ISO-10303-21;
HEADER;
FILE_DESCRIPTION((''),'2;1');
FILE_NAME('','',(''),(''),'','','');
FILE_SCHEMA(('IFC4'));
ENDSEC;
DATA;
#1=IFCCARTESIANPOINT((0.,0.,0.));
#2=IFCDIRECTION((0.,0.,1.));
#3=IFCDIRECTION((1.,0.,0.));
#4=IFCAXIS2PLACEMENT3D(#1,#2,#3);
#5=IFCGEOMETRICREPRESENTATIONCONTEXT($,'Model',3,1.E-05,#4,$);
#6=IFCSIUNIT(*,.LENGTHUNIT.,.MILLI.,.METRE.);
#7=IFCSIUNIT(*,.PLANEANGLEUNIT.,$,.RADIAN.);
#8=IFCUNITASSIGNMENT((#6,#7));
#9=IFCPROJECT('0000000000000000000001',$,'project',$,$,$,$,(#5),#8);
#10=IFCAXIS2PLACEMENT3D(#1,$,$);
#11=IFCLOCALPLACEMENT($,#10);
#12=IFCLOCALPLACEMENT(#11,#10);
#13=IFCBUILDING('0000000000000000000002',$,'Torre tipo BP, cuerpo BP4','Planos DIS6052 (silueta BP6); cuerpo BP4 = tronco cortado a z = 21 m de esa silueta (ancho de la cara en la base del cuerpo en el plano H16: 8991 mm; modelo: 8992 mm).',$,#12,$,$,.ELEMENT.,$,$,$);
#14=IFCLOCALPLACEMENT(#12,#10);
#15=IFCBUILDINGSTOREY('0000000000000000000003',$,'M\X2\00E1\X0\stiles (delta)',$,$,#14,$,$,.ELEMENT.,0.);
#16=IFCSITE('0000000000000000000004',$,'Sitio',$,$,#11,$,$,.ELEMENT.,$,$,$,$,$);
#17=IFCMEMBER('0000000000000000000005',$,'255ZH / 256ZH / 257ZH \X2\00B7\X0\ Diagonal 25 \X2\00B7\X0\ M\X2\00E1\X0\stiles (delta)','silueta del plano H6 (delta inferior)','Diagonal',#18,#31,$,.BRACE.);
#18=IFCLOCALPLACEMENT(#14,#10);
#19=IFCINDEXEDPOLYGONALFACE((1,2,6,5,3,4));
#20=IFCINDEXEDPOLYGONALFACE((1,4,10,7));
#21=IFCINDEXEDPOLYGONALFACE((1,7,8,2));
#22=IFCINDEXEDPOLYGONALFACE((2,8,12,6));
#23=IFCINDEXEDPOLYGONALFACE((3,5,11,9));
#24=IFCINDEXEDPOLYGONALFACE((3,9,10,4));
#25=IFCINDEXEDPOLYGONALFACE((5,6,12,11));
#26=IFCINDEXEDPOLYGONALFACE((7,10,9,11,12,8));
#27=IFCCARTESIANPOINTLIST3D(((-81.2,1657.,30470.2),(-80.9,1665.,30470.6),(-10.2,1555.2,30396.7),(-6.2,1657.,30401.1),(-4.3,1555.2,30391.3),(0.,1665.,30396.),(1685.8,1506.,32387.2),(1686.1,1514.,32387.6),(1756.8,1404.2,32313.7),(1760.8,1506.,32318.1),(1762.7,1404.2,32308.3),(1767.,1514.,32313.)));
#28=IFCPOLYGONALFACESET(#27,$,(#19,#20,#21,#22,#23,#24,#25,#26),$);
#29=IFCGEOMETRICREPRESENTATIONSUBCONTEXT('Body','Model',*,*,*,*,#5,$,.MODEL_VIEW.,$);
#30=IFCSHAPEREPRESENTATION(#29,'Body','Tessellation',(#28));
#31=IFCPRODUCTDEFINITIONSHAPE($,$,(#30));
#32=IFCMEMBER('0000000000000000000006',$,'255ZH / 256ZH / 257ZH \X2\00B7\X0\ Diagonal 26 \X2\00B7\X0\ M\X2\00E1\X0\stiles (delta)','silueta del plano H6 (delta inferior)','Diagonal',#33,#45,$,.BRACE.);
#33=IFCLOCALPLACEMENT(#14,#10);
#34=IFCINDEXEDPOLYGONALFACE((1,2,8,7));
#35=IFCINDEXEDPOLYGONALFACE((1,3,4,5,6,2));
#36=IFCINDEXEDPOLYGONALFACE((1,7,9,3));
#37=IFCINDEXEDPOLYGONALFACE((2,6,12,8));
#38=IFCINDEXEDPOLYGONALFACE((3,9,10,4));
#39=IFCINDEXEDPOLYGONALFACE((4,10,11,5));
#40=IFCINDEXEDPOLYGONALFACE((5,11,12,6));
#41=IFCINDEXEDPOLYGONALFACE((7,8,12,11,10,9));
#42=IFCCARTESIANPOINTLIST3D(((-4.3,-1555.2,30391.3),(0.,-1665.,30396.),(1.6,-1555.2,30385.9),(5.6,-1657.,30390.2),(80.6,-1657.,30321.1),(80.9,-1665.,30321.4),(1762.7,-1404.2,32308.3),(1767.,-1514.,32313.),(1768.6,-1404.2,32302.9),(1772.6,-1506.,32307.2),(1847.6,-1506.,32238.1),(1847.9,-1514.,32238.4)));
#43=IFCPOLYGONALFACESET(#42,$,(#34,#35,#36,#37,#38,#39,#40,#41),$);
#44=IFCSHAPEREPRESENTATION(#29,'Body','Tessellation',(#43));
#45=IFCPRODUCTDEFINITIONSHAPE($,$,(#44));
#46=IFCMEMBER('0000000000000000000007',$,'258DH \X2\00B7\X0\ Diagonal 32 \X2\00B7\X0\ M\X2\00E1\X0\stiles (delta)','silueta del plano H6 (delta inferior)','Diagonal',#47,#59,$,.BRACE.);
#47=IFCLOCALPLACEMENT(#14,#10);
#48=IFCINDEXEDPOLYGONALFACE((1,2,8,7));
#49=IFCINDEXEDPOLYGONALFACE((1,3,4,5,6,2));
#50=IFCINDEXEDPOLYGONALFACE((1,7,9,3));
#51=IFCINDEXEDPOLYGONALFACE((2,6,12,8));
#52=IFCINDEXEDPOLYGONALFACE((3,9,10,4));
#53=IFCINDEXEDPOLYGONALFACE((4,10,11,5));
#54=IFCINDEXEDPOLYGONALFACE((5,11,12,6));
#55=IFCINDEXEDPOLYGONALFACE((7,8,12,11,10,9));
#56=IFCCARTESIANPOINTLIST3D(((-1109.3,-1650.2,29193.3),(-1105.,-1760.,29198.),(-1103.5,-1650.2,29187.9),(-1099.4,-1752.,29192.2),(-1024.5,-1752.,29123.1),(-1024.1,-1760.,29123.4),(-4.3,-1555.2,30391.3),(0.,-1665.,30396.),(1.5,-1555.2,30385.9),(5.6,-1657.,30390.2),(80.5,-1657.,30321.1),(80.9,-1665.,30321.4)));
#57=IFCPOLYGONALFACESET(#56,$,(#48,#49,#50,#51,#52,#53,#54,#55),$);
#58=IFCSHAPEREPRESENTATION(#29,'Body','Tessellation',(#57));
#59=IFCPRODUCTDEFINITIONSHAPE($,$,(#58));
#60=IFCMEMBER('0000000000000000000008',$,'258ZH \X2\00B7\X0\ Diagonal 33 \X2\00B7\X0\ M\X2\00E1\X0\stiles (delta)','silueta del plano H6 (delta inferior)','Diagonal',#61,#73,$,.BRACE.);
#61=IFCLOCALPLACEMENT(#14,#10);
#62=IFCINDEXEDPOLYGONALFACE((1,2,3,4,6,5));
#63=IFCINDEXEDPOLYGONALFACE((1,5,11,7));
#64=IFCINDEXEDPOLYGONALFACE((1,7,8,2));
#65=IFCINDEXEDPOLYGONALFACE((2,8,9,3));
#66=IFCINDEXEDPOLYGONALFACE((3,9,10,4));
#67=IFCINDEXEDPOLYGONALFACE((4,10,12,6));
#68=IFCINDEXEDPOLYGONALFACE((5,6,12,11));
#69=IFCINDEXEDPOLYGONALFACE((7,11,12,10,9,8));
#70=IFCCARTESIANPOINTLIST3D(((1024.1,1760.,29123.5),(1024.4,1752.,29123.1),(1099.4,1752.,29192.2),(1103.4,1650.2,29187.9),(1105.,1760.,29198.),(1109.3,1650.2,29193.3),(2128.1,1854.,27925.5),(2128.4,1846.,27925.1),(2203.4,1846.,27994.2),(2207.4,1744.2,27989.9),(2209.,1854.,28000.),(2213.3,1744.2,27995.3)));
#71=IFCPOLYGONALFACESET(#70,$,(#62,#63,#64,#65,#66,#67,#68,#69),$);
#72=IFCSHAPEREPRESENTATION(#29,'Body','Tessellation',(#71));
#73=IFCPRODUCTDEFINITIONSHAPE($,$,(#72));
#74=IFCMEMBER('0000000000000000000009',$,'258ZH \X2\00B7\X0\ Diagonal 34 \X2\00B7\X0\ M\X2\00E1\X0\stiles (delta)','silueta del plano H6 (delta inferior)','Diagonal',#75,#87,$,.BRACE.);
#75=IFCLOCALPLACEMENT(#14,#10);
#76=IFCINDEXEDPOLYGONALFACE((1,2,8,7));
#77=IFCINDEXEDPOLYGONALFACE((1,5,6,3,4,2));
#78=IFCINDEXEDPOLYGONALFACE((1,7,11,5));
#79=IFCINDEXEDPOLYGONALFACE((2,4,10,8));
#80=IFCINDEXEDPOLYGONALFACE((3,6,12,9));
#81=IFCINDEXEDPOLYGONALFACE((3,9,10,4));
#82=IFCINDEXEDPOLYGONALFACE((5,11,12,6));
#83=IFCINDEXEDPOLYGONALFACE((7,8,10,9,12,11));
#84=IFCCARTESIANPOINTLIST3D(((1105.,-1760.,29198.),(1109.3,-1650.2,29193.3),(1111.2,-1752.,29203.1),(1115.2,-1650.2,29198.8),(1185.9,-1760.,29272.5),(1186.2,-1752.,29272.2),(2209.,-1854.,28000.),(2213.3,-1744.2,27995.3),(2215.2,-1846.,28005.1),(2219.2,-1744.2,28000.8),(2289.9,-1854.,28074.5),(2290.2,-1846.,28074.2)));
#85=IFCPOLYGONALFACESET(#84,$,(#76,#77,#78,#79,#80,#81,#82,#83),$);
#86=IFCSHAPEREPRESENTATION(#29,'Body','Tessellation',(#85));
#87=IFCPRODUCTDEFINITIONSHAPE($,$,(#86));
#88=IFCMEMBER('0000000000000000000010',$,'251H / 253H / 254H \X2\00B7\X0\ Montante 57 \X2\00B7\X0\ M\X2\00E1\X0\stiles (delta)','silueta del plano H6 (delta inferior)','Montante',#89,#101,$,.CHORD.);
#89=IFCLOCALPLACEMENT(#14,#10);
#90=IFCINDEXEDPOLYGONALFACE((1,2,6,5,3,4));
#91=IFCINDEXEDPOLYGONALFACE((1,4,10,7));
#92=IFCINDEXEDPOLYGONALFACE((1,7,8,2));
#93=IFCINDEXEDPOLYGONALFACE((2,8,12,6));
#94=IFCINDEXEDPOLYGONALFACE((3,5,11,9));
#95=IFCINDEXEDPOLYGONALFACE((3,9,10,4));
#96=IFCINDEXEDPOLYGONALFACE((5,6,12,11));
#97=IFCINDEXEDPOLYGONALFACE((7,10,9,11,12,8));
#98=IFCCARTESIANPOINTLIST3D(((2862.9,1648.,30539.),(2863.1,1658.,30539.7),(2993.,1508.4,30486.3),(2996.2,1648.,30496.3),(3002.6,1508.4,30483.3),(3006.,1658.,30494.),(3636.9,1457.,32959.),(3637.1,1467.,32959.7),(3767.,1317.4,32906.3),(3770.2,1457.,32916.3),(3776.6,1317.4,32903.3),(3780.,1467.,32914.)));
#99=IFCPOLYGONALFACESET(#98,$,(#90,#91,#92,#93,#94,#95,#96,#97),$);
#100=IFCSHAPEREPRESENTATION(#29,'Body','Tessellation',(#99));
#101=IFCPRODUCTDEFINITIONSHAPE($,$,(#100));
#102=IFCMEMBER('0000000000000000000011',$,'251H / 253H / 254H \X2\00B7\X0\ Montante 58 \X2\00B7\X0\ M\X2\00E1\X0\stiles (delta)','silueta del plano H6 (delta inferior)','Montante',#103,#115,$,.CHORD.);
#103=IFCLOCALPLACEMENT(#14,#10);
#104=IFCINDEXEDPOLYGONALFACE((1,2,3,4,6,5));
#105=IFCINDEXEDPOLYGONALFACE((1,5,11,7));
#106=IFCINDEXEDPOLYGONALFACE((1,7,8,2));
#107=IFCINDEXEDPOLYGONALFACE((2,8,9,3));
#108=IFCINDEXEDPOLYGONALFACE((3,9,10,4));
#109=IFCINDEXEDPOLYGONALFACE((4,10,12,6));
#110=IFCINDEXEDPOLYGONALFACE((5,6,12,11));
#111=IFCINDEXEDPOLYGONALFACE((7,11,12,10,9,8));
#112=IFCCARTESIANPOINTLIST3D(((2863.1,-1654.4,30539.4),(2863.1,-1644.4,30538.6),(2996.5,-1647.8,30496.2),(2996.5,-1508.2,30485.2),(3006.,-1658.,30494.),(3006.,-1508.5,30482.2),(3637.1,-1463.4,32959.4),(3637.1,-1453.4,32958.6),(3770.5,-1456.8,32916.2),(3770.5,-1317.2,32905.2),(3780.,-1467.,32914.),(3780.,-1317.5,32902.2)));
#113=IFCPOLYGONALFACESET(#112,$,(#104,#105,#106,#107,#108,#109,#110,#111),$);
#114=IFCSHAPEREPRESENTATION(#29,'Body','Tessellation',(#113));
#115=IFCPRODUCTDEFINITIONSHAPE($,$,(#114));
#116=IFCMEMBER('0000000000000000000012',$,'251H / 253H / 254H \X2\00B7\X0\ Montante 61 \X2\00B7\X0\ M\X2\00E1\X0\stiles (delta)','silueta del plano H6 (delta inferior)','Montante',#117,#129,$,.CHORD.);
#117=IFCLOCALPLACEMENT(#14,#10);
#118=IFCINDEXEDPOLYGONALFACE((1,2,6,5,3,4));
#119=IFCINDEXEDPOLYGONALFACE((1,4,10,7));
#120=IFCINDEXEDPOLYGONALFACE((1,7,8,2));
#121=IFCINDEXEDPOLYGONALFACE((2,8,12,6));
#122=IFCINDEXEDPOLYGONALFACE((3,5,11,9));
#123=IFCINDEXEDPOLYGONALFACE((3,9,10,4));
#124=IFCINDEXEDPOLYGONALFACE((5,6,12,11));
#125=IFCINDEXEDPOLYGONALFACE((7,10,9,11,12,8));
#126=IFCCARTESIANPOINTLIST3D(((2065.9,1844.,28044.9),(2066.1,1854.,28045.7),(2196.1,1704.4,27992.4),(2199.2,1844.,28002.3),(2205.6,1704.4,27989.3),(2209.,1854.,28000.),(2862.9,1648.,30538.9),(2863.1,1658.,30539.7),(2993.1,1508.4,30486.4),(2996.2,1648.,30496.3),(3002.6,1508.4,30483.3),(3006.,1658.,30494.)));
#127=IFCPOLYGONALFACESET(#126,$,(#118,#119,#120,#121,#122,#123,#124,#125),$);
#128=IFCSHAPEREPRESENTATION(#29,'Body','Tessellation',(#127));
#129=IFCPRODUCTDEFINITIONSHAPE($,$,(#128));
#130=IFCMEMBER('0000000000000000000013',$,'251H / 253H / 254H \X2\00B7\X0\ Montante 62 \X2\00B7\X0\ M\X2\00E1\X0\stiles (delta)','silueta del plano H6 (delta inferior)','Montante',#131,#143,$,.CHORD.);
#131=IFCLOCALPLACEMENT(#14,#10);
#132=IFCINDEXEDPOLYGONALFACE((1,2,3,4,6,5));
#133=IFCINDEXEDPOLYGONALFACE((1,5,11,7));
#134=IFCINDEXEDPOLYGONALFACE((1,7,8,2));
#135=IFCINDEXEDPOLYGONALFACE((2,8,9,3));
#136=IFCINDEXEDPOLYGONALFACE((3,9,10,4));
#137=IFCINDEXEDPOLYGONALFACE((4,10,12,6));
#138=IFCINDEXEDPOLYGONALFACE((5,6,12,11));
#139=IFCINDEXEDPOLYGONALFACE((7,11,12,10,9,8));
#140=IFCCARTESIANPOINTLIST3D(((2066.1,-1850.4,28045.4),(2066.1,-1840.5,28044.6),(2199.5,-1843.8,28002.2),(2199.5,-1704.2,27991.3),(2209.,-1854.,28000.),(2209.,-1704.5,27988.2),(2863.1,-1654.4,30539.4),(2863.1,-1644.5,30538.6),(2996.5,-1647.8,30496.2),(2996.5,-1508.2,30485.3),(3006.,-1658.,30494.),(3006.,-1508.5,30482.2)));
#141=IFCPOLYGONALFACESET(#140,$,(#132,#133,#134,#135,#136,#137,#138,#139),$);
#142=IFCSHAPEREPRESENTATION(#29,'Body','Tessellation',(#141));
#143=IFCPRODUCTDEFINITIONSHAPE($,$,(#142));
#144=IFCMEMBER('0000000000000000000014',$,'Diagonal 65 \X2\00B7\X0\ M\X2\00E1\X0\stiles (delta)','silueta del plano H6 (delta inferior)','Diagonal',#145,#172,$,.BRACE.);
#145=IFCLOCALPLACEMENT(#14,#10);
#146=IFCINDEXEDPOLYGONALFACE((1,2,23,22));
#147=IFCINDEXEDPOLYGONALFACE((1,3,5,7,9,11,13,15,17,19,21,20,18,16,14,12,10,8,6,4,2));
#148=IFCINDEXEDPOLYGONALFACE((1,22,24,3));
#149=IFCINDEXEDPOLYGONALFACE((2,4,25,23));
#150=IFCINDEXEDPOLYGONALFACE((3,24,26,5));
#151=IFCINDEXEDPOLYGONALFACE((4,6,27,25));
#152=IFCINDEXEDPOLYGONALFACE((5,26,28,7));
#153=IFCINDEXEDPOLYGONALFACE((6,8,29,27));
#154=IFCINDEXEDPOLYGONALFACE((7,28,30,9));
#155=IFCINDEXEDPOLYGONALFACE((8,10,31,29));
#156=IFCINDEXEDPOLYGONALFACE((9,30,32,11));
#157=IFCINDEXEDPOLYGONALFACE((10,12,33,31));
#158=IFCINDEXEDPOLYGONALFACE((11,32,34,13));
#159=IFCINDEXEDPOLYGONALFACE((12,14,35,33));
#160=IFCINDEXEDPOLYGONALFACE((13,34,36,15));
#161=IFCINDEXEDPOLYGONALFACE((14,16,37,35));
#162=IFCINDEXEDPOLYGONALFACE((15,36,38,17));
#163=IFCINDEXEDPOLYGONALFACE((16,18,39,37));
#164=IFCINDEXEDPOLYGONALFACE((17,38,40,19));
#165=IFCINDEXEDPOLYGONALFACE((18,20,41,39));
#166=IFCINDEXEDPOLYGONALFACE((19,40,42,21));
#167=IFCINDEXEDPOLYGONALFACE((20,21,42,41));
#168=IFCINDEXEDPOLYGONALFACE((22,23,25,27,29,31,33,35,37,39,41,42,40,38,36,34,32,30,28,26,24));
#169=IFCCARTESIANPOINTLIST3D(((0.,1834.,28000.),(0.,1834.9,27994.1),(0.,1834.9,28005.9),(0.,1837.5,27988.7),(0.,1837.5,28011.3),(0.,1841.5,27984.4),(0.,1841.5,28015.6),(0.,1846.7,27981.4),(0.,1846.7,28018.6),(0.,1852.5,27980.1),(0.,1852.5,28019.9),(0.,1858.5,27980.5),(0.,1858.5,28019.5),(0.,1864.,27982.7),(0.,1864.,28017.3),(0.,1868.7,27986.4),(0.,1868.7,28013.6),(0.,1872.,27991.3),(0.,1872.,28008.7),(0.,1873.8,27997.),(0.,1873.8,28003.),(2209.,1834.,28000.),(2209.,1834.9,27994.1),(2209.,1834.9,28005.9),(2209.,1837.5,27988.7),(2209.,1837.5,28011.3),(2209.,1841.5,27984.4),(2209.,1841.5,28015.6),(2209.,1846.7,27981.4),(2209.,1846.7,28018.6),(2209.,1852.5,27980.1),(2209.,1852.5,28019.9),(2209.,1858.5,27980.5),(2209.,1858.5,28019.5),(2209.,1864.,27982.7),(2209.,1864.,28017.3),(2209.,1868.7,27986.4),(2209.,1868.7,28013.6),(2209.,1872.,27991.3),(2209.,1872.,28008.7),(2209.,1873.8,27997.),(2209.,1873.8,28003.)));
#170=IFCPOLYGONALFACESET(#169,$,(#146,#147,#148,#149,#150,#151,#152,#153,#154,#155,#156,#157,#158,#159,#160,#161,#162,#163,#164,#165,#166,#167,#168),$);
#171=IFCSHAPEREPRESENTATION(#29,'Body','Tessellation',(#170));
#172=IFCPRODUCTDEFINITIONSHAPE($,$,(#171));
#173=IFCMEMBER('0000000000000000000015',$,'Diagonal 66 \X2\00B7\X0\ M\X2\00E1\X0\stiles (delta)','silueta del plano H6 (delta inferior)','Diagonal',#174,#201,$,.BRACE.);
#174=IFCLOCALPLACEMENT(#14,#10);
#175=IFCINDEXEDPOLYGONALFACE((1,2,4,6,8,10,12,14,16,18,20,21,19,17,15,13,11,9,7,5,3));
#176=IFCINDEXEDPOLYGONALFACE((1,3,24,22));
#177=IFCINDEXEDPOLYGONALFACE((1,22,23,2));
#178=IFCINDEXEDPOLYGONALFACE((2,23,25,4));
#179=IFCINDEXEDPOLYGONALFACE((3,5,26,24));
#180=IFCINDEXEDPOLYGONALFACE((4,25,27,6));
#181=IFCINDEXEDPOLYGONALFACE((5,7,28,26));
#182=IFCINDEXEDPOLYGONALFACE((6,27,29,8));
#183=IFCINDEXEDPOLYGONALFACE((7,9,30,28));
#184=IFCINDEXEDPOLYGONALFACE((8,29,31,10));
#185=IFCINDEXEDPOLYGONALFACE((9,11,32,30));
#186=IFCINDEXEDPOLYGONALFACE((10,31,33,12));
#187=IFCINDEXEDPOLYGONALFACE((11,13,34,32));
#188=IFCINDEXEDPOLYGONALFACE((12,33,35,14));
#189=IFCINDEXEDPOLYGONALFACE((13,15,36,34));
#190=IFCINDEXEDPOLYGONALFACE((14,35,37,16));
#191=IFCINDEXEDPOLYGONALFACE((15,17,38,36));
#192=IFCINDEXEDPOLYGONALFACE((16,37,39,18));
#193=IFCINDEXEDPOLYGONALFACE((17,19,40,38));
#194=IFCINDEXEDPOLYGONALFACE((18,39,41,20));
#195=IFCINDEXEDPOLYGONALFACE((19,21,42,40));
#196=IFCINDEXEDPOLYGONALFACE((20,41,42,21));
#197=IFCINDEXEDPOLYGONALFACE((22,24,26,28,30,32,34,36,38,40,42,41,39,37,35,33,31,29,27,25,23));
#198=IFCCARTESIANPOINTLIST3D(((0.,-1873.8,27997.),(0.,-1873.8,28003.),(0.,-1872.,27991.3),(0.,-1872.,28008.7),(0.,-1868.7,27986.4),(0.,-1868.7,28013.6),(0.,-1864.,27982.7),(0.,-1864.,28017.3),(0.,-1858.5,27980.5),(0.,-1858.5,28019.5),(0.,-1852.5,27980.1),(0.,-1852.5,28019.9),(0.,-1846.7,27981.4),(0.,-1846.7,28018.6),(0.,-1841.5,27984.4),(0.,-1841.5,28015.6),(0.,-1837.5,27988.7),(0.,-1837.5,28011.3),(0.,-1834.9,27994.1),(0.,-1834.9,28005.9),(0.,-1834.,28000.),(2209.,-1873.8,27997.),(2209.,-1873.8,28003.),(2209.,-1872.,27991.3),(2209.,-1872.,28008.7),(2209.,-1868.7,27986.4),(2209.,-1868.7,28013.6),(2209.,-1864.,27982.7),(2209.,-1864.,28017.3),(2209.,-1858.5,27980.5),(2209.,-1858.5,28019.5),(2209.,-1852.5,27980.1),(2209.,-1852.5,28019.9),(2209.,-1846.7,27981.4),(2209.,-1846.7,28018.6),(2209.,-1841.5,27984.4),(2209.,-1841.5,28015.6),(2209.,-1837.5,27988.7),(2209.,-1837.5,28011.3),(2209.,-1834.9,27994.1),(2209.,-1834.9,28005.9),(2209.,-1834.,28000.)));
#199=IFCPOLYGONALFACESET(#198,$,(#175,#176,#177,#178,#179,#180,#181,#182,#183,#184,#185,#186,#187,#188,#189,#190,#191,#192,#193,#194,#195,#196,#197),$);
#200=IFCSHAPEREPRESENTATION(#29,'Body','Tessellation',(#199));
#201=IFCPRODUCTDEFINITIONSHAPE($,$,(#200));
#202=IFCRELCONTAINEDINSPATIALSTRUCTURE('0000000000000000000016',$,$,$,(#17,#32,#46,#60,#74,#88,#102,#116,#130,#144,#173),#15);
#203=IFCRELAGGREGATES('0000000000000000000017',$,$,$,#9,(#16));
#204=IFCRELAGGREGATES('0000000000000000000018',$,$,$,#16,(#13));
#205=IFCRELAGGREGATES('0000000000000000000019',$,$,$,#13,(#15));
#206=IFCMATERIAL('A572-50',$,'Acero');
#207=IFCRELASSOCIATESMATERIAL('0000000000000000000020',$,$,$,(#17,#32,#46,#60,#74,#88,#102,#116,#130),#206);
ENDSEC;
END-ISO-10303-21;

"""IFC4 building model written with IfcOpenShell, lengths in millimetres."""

from ifc_helpers import new_model, si_unit, frame, frame_2d, origin, origin_with_axes, place, context, subcontext, project, spatial, circle, l_section, extrude, material, element, save


model = new_model("IFC4")

# Units and contexts
model_context = context("Model", 3, precision=1e-05, world=origin_with_axes())
body_context = subcontext(model_context, "Body", "Model", "MODEL_VIEW")
ifc_project = project(units=[si_unit("LENGTHUNIT", "METRE", prefix="MILLI"), si_unit("PLANEANGLEUNIT", "RADIAN")], contexts=[model_context])

# Site, building, storey
site_placement = place(None, origin())
site = spatial("IfcSite", under=ifc_project, at=site_placement, Name="Sitio", CompositionType="ELEMENT")
building_placement = place(site_placement, origin())
building = spatial("IfcBuilding", under=site, at=building_placement, Name="Torre tipo BP, cuerpo BP4", Description="Planos DIS6052 (silueta BP6); cuerpo BP4 = tronco cortado a z = 21 m de esa silueta (ancho de la cara en la base del cuerpo en el plano H16: 8991 mm; modelo: 8992 mm).", CompositionType="ELEMENT")
storey_placement = place(building_placement, origin())
storey = spatial("IfcBuildingStorey", under=building, at=storey_placement, Name="Mástiles (delta)", CompositionType="ELEMENT", Elevation=0.0)

# Members
ifc_material = material(Name="A572-50", Category="Acero")
for number, where, z_axis, x_axis, name in (
    (1, (1767.0, 1514.0, 32313.0), (-0.67662, 0.057821, -0.734058), (-0.039188, -0.998327, -0.042515), "255ZH / 256ZH / 257ZH · Diagonal 25 · Mástiles (delta)"),
    (2, (1767.0, -1514.0, 32313.0), (-0.67662, -0.057821, -0.734058), (-0.039188, 0.998327, -0.042515), "255ZH / 256ZH / 257ZH · Diagonal 26 · Mástiles (delta)"),
):
    element("IfcMember", number, at=place(storey_placement, frame(where, z_axis=z_axis, x_axis=x_axis)), inside=storey, material=ifc_material, Name=name, Description="silueta del plano H6 (delta inferior)", ObjectType="Diagonal", PredefinedType="BRACE", context=body_context, shape_type="SweptSolid", body=[
        extrude(l_section(Depth=110.0, Width=110.0, Thickness=8.0, at=frame_2d((55.0, 55.0))), None, (0.0, 0.0, 1.0), 2611.5),
    ])
member_1_placement = place(storey_placement, frame((0.0, -1665.0, 30396.0), z_axis=(-0.676851, -0.058191, -0.733817), x_axis=(-0.039453, 0.998305, -0.042774)))
element("IfcMember", 3, at=member_1_placement, inside=storey, material=ifc_material, Name="258DH · Diagonal 32 · Mástiles (delta)", Description="silueta del plano H6 (delta inferior)", ObjectType="Diagonal", PredefinedType="BRACE", context=body_context, shape_type="SweptSolid", body=[
    extrude(l_section(Depth=110.0, Width=110.0, Thickness=8.0, at=frame_2d((55.0, 55.0))), None, (0.0, 0.0, 1.0), 1632.6),
])
for number, where, z_axis, x_axis, name in (
    (4, (1105.0, 1760.0, 29198.0), (0.676543, 0.057604, -0.734147), (0.039037, -0.99834, -0.04236), "258ZH · Diagonal 33 · Mástiles (delta)"),
    (5, (1105.0, -1760.0, 29198.0), (0.676543, -0.057604, -0.734147), (0.039037, 0.99834, -0.04236), "258ZH · Diagonal 34 · Mástiles (delta)"),
):
    element("IfcMember", number, at=place(storey_placement, frame(where, z_axis=z_axis, x_axis=x_axis)), inside=storey, material=ifc_material, Name=name, Description="silueta del plano H6 (delta inferior)", ObjectType="Diagonal", PredefinedType="BRACE", context=body_context, shape_type="SweptSolid", body=[
        extrude(l_section(Depth=110.0, Width=110.0, Thickness=8.0, at=frame_2d((55.0, 55.0))), None, (0.0, 0.0, 1.0), 1631.8),
    ])
for number, where, z_axis, x_axis, name in (
    (6, (3780.0, 1467.0, 32914.0), (-0.303776, 0.074963, -0.94979), (-0.022836, -0.997186, -0.0714), "251H / 253H / 254H · Montante 57 · Mástiles (delta)"),
    (7, (3780.0, -1467.0, 32914.0), (-0.303776, -0.074963, -0.94979), (-0.952744, 0.023901, 0.302834), "251H / 253H / 254H · Montante 58 · Mástiles (delta)"),
):
    element("IfcMember", number, at=place(storey_placement, frame(where, z_axis=z_axis, x_axis=x_axis)), inside=storey, material=ifc_material, Name=name, Description="silueta del plano H6 (delta inferior)", ObjectType="Montante", PredefinedType="CHORD", context=body_context, shape_type="SweptSolid", body=[
        extrude(l_section(Depth=150.0, Width=150.0, Thickness=10.0, at=frame_2d((75.0, 75.0))), None, (0.0, 0.0, 1.0), 2547.9),
    ])
for number, where, z_axis, x_axis, name in (
    (8, (3006.0, 1658.0, 30494.0), (-0.303552, 0.07465, -0.949886), (-0.022724, -0.99721, -0.071108), "251H / 253H / 254H · Montante 61 · Mástiles (delta)"),
    (9, (3006.0, -1658.0, 30494.0), (-0.303552, -0.07465, -0.949886), (-0.952815, 0.023782, 0.302619), "251H / 253H / 254H · Montante 62 · Mástiles (delta)"),
):
    element("IfcMember", number, at=place(storey_placement, frame(where, z_axis=z_axis, x_axis=x_axis)), inside=storey, material=ifc_material, Name=name, Description="silueta del plano H6 (delta inferior)", ObjectType="Montante", PredefinedType="CHORD", context=body_context, shape_type="SweptSolid", body=[
        extrude(l_section(Depth=150.0, Width=150.0, Thickness=10.0, at=frame_2d((75.0, 75.0))), None, (0.0, 0.0, 1.0), 2625.6),
    ])
for number, where, z_axis, x_axis, name in (
    (10, (2209.0, 1854.0, 28000.0), (-1.0, 0.0, 0.0), (0.0, -1.0, 0.0), "Diagonal 65 · Mástiles (delta)"),
    (11, (2209.0, -1854.0, 28000.0), (-1.0, 0.0, 0.0), (0.0, 1.0, 0.0), "Diagonal 66 · Mástiles (delta)"),
):
    element("IfcMember", number, at=place(storey_placement, frame(where, z_axis=z_axis, x_axis=x_axis)), inside=storey, Name=name, Description="silueta del plano H6 (delta inferior)", ObjectType="Diagonal", PredefinedType="BRACE", context=body_context, shape_type="SweptSolid", body=[
        extrude(circle(Radius=20.0), None, (0.0, 0.0, 1.0), 2209.0),
    ])

save(model, "model.ifc")
